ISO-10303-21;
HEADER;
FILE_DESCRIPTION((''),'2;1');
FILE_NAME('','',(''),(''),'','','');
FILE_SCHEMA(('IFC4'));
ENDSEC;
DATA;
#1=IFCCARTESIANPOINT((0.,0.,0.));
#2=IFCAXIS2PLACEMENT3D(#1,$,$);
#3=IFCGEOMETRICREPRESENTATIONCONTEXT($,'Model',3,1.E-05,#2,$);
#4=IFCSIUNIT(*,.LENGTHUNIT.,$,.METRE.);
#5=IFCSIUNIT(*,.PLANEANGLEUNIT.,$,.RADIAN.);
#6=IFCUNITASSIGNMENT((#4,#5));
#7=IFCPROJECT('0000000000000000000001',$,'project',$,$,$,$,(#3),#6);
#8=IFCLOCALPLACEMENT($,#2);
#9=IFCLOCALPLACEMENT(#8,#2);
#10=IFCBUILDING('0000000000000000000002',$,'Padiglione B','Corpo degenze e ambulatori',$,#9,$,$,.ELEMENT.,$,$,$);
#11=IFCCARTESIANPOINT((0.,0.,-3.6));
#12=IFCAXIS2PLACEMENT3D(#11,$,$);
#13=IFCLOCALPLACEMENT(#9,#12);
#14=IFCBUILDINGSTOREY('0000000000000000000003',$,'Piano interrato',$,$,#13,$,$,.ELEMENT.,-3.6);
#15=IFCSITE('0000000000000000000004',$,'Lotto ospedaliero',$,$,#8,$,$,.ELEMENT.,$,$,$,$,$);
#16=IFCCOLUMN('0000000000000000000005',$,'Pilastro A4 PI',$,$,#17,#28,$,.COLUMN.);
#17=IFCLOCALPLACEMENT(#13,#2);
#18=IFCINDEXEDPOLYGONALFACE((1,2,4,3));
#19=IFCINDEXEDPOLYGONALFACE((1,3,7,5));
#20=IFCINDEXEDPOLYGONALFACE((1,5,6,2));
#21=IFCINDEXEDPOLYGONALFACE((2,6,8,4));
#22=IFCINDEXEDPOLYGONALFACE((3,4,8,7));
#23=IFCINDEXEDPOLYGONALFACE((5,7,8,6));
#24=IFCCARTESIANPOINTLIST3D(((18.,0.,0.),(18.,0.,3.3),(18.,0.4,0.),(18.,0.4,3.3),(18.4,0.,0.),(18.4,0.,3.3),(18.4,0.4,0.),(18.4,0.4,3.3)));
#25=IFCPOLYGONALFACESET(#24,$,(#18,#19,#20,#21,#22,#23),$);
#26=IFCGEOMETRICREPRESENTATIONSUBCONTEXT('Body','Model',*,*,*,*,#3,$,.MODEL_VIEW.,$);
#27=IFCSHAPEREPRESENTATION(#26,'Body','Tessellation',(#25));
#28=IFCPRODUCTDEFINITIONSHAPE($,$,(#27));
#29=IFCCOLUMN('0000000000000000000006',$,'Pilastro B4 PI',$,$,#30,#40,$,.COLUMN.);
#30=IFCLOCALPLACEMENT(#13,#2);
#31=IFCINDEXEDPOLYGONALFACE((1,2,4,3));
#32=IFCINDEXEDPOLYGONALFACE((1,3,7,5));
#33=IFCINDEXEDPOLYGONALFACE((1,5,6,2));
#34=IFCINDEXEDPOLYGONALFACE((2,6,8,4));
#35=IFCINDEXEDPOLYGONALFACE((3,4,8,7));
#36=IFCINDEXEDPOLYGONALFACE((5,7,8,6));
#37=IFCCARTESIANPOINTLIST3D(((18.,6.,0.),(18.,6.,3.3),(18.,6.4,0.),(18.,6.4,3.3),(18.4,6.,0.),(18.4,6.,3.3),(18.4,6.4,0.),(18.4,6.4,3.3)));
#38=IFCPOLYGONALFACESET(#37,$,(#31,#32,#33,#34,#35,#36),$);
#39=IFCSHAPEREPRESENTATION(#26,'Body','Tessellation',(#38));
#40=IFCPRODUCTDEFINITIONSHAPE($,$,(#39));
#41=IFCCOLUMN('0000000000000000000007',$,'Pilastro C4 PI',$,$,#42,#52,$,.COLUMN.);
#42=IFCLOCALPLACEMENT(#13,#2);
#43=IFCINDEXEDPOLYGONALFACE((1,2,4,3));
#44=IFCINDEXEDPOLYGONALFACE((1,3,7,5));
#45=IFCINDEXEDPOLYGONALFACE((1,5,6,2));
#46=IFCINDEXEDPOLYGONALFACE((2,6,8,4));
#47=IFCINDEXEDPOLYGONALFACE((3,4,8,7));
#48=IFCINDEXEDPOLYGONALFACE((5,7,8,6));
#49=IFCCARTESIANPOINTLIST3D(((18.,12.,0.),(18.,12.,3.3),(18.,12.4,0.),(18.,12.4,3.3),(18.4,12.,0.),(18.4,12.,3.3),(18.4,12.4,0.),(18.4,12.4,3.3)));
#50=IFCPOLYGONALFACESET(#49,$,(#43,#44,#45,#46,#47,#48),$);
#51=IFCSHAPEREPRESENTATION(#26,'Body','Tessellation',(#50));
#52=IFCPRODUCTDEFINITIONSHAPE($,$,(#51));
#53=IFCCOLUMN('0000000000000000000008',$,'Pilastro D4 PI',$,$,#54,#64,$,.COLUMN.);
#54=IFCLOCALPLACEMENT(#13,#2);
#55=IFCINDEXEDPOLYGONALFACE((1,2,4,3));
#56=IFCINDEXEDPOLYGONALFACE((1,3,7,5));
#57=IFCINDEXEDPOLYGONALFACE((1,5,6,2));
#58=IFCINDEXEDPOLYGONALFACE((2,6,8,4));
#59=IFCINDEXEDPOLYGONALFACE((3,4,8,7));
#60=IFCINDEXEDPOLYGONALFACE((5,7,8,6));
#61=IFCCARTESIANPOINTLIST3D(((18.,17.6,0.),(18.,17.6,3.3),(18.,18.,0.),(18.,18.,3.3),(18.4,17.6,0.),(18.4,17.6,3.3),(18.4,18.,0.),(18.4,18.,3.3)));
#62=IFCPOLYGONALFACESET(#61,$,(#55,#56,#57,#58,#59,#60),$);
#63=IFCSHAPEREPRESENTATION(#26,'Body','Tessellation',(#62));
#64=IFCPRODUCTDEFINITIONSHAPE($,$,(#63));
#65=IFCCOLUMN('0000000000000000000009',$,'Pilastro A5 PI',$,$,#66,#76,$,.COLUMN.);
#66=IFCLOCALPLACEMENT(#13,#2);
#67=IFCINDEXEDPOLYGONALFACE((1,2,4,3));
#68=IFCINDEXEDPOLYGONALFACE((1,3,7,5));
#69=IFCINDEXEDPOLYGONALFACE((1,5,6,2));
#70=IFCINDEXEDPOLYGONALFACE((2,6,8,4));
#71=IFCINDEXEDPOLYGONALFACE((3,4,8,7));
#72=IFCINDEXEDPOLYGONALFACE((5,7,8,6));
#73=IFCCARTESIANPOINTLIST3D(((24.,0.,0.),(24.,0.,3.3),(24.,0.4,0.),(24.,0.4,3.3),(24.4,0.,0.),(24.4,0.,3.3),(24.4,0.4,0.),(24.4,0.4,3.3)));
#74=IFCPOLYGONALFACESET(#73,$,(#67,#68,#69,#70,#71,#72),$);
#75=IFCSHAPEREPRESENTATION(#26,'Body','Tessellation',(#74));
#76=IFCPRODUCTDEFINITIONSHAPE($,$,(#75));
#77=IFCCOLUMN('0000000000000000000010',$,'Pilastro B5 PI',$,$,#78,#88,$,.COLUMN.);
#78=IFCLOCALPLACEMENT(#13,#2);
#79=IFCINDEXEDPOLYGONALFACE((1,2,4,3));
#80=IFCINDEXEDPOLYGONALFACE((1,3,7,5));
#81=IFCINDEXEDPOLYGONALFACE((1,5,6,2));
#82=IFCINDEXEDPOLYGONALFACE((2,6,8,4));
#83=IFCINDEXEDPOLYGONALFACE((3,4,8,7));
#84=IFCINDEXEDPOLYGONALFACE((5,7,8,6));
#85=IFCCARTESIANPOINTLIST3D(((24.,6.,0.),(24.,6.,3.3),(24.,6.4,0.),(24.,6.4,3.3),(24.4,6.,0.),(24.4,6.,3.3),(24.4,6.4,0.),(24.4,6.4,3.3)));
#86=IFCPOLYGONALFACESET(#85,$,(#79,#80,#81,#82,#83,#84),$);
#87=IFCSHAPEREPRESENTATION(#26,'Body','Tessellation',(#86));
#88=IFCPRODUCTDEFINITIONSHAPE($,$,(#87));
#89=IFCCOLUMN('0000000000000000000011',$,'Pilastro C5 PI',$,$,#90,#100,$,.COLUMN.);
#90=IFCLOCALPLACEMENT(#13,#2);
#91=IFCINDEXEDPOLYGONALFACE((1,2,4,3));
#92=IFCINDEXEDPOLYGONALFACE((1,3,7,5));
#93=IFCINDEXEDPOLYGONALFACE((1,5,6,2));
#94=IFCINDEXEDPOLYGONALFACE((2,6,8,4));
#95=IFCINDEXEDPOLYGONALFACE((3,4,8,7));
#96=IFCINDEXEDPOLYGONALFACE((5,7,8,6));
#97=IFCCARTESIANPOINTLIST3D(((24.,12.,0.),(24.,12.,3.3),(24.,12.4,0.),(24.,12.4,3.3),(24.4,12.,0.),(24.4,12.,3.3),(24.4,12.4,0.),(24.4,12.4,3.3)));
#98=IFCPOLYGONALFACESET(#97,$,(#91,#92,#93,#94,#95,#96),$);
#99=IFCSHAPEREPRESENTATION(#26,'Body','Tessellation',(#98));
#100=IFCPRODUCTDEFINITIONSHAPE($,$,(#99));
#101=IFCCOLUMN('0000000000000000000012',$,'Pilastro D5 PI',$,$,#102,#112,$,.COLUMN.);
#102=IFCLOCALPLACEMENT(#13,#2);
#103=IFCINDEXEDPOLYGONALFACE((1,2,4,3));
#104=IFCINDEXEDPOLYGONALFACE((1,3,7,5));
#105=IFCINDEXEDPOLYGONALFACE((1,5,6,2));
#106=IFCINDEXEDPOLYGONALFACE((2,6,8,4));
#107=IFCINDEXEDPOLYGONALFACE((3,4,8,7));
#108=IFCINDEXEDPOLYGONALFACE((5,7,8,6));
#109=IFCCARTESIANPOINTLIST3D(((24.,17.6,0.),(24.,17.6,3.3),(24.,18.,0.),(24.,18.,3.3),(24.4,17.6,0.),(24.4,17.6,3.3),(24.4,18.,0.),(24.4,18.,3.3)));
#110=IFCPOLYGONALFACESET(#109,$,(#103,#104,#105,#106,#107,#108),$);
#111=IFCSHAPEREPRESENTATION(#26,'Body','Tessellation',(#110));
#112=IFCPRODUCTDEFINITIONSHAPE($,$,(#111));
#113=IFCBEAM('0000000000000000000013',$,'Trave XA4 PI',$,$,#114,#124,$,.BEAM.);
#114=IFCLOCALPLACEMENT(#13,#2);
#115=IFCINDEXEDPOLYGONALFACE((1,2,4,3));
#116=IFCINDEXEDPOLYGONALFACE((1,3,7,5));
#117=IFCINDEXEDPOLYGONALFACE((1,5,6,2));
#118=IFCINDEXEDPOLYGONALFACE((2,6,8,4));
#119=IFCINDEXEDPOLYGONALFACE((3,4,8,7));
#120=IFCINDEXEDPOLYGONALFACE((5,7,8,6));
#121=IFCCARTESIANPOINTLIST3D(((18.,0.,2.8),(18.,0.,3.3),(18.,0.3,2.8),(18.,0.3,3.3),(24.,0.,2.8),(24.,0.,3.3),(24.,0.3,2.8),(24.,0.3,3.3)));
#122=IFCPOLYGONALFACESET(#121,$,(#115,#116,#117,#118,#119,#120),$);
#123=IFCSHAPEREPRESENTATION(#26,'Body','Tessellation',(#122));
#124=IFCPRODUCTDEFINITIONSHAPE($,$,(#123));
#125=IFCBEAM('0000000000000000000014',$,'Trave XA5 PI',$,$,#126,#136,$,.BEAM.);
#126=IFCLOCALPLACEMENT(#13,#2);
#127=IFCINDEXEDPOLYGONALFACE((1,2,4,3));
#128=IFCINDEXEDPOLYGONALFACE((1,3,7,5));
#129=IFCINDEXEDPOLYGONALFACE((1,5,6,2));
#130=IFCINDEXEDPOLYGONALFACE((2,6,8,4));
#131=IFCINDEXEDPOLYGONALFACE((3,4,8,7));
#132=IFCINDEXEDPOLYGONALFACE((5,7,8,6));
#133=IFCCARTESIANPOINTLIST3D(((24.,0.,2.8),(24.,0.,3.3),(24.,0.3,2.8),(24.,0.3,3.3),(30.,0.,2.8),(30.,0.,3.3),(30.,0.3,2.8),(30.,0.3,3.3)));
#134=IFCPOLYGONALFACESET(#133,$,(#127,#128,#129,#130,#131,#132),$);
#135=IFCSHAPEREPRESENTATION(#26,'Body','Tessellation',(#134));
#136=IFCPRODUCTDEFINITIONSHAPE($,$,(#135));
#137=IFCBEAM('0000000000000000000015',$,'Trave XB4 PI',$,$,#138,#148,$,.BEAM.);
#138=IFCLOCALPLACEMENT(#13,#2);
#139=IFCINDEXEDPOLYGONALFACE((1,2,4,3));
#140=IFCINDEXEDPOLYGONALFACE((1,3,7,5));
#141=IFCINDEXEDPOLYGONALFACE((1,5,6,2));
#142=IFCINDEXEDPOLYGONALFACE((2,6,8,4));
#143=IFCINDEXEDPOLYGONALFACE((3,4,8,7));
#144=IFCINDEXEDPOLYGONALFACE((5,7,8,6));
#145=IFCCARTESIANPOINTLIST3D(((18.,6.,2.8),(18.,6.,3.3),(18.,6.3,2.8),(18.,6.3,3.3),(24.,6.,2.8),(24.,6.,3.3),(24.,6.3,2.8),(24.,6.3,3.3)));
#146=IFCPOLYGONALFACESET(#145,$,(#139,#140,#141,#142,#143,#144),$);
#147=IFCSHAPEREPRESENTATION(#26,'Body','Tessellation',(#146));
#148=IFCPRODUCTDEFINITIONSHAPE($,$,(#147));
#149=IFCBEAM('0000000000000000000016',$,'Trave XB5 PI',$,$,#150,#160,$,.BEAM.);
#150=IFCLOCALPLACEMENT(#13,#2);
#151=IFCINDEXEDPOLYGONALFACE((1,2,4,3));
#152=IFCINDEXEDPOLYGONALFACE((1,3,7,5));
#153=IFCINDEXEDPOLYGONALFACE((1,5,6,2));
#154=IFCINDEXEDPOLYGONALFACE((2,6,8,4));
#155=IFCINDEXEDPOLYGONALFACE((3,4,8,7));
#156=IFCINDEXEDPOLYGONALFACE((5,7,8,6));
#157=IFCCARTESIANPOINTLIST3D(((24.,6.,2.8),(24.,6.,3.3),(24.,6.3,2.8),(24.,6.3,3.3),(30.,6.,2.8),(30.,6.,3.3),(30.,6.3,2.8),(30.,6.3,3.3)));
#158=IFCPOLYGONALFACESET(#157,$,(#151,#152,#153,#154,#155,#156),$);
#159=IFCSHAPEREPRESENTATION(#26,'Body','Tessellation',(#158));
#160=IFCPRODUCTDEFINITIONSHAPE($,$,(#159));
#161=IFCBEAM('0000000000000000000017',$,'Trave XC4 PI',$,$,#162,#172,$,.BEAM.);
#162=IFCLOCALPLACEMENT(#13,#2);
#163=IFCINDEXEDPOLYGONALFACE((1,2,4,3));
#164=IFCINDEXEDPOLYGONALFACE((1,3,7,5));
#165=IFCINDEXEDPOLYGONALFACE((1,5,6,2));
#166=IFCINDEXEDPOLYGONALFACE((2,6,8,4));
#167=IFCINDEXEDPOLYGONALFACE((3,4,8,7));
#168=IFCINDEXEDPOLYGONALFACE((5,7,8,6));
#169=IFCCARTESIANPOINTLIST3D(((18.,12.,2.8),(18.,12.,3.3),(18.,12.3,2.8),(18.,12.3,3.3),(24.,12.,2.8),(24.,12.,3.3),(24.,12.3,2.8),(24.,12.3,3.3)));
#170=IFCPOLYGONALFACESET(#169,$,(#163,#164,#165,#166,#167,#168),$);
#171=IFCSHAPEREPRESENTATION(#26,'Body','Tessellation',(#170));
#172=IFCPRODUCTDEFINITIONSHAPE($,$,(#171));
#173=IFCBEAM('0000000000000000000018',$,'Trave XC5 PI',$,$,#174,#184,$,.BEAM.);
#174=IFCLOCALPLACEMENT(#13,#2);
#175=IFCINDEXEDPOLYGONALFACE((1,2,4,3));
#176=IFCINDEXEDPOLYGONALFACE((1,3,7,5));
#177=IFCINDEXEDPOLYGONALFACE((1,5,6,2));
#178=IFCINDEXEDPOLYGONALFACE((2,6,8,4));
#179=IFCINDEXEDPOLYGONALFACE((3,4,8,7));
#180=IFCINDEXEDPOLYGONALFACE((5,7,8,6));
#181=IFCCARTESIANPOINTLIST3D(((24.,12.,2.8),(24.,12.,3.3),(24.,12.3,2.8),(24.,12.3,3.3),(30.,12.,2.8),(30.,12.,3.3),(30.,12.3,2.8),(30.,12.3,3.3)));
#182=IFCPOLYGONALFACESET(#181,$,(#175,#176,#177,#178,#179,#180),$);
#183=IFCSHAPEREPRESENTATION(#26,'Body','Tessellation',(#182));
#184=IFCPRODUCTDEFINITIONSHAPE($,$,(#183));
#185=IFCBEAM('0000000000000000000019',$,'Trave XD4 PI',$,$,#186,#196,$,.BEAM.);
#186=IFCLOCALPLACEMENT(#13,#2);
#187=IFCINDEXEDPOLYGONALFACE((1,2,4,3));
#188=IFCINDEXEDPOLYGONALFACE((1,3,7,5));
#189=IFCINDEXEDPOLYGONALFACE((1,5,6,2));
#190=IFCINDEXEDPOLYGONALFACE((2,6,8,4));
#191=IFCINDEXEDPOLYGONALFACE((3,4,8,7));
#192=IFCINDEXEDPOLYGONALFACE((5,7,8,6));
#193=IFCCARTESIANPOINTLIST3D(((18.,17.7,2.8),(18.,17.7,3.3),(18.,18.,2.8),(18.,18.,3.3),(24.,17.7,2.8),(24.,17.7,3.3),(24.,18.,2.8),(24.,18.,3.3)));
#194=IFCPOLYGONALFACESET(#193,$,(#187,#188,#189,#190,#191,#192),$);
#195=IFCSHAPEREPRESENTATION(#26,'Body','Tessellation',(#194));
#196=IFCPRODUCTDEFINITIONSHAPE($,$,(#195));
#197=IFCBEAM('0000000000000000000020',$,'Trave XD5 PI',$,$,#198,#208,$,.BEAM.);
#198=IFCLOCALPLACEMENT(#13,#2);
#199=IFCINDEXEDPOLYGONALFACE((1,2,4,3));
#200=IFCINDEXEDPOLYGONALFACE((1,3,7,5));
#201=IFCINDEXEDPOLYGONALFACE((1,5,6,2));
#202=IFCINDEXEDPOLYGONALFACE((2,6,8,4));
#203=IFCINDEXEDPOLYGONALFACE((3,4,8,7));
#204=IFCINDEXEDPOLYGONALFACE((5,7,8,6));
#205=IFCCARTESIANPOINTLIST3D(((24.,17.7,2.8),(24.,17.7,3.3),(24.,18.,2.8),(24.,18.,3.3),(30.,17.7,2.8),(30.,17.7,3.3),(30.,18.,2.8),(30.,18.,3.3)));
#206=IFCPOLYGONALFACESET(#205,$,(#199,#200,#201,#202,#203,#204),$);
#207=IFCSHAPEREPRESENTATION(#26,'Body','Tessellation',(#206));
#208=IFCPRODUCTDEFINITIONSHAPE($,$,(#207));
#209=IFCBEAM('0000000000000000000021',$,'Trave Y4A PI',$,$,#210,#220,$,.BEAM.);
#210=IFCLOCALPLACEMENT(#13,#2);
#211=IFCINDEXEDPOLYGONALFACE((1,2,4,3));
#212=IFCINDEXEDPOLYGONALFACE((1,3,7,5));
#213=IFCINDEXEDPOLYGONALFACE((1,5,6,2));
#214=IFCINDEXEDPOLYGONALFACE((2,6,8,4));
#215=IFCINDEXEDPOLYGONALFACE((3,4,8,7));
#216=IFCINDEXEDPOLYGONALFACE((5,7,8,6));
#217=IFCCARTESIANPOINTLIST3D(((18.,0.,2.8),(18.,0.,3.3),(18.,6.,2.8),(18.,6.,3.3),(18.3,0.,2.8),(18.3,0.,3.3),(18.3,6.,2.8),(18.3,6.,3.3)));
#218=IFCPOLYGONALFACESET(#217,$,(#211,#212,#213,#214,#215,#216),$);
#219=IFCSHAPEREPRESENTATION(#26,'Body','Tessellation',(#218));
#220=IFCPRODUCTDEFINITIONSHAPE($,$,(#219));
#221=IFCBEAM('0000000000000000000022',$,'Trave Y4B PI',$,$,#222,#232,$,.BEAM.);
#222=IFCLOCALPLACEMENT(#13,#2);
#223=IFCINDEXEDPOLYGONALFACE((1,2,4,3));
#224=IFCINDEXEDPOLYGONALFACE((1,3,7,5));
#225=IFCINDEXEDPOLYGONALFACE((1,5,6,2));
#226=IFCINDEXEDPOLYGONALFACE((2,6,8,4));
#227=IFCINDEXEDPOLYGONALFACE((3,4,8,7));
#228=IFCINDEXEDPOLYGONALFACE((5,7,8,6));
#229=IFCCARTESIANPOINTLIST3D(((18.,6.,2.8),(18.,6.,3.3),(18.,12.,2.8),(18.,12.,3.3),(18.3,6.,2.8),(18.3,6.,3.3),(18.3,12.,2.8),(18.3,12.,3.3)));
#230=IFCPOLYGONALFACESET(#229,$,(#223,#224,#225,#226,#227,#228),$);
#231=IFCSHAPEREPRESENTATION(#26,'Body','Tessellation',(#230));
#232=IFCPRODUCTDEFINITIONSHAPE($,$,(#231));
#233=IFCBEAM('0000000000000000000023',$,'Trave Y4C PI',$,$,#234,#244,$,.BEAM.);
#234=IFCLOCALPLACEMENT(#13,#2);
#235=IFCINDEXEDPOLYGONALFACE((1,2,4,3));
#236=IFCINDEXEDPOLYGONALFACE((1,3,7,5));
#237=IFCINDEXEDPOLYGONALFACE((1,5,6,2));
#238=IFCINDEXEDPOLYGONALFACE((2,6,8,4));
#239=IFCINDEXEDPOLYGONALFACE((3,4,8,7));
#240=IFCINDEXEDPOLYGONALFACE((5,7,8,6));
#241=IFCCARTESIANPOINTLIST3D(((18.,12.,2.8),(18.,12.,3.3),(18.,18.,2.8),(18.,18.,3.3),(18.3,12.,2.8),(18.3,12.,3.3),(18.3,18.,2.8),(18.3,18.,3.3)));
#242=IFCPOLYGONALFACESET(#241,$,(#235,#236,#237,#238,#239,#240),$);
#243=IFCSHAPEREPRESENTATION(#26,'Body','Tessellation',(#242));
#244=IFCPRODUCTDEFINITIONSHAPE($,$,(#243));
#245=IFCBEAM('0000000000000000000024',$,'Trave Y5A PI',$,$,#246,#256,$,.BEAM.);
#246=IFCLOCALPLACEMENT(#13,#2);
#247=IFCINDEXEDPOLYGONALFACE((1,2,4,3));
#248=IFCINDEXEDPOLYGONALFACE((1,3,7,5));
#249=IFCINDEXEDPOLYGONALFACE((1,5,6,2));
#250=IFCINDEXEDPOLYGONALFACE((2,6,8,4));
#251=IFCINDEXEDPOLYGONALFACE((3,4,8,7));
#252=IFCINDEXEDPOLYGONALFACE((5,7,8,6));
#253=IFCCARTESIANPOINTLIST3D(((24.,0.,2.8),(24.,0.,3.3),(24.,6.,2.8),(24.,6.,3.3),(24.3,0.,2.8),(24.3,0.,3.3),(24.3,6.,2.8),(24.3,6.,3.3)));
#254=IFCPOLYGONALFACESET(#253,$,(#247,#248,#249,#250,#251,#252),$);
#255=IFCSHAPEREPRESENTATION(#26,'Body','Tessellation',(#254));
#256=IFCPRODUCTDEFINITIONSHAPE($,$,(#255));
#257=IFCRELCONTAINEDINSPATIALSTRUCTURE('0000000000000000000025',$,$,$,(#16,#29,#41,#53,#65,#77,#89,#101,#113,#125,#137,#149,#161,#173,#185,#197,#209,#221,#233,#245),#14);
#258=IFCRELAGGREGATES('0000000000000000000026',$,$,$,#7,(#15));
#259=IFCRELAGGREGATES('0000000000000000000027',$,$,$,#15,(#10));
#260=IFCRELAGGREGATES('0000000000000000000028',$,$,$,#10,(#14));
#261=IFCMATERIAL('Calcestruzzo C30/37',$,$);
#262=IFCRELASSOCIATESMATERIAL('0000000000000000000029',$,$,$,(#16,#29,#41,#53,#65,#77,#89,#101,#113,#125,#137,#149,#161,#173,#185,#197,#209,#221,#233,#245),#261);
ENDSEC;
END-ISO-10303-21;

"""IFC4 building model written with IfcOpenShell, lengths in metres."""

from ifc_helpers import new_model, si_unit, frame, frame_2d, origin, place, context, subcontext, project, spatial, rectangle, extrude, material, element, save


model = new_model("IFC4")

# Units and contexts
model_context = context("Model", 3, precision=1e-05, world=origin())
body_context = subcontext(model_context, "Body", "Model", "MODEL_VIEW")
ifc_project = project(units=[si_unit("LENGTHUNIT", "METRE"), si_unit("PLANEANGLEUNIT", "RADIAN")], contexts=[model_context])

# Site, building, storey
site_placement = place(None, origin())
site = spatial("IfcSite", under=ifc_project, at=site_placement, Name="Lotto ospedaliero", CompositionType="ELEMENT")
building_placement = place(site_placement, origin())
building = spatial("IfcBuilding", under=site, at=building_placement, Name="Padiglione B", Description="Corpo degenze e ambulatori", CompositionType="ELEMENT")
storey_placement = place(building_placement, frame((0.0, 0.0, -3.6)))
storey = spatial("IfcBuildingStorey", under=building, at=storey_placement, Name="Piano interrato", CompositionType="ELEMENT", Elevation=-3.6)

# Columns
ifc_material_1 = material(Name="Calcestruzzo C30/37")
for number, where, name in (
    (1, (18.0, 0.0, 0.0), "Pilastro A4 PI"),
    (2, (18.0, 6.0, 0.0), "Pilastro B4 PI"),
    (3, (18.0, 12.0, 0.0), "Pilastro C4 PI"),
    (4, (18.0, 17.6, 0.0), "Pilastro D4 PI"),
    (5, (24.0, 0.0, 0.0), "Pilastro A5 PI"),
    (6, (24.0, 6.0, 0.0), "Pilastro B5 PI"),
    (7, (24.0, 12.0, 0.0), "Pilastro C5 PI"),
    (8, (24.0, 17.6, 0.0), "Pilastro D5 PI"),
):
    element("IfcColumn", number, at=place(storey_placement, frame(where)), inside=storey, material=ifc_material_1, Name=name, PredefinedType="COLUMN", context=body_context, shape_type="SweptSolid", body=[
        extrude(rectangle(XDim=0.4, YDim=0.4, at=frame_2d((0.2, 0.2))), origin(), (0.0, 0.0, 1.0), 3.3),
    ])

# Beams
for number, where, name in (
    (9, (18.0, 0.0, 2.8), "Trave XA4 PI"),
    (10, (24.0, 0.0, 2.8), "Trave XA5 PI"),
    (11, (18.0, 6.0, 2.8), "Trave XB4 PI"),
    (12, (24.0, 6.0, 2.8), "Trave XB5 PI"),
    (13, (18.0, 12.0, 2.8), "Trave XC4 PI"),
    (14, (24.0, 12.0, 2.8), "Trave XC5 PI"),
    (15, (18.0, 17.7, 2.8), "Trave XD4 PI"),
    (16, (24.0, 17.7, 2.8), "Trave XD5 PI"),
):
    element("IfcBeam", number, at=place(storey_placement, frame(where)), inside=storey, material=ifc_material_1, Name=name, PredefinedType="BEAM", context=body_context, shape_type="SweptSolid", body=[
        extrude(rectangle(XDim=6.0, YDim=0.3, at=frame_2d((3.0, 0.15))), origin(), (0.0, 0.0, 1.0), 0.5),
    ])
for number, where, name in (
    (17, (18.0, 0.0, 2.8), "Trave Y4A PI"),
    (18, (18.0, 6.0, 2.8), "Trave Y4B PI"),
    (19, (18.0, 12.0, 2.8), "Trave Y4C PI"),
    (20, (24.0, 0.0, 2.8), "Trave Y5A PI"),
):
    element("IfcBeam", number, at=place(storey_placement, frame(where)), inside=storey, material=ifc_material_1, Name=name, PredefinedType="BEAM", context=body_context, shape_type="SweptSolid", body=[
        extrude(rectangle(XDim=0.3, YDim=6.0, at=frame_2d((0.15, 3.0))), origin(), (0.0, 0.0, 1.0), 0.5),
    ])

save(model, "model.ifc")
